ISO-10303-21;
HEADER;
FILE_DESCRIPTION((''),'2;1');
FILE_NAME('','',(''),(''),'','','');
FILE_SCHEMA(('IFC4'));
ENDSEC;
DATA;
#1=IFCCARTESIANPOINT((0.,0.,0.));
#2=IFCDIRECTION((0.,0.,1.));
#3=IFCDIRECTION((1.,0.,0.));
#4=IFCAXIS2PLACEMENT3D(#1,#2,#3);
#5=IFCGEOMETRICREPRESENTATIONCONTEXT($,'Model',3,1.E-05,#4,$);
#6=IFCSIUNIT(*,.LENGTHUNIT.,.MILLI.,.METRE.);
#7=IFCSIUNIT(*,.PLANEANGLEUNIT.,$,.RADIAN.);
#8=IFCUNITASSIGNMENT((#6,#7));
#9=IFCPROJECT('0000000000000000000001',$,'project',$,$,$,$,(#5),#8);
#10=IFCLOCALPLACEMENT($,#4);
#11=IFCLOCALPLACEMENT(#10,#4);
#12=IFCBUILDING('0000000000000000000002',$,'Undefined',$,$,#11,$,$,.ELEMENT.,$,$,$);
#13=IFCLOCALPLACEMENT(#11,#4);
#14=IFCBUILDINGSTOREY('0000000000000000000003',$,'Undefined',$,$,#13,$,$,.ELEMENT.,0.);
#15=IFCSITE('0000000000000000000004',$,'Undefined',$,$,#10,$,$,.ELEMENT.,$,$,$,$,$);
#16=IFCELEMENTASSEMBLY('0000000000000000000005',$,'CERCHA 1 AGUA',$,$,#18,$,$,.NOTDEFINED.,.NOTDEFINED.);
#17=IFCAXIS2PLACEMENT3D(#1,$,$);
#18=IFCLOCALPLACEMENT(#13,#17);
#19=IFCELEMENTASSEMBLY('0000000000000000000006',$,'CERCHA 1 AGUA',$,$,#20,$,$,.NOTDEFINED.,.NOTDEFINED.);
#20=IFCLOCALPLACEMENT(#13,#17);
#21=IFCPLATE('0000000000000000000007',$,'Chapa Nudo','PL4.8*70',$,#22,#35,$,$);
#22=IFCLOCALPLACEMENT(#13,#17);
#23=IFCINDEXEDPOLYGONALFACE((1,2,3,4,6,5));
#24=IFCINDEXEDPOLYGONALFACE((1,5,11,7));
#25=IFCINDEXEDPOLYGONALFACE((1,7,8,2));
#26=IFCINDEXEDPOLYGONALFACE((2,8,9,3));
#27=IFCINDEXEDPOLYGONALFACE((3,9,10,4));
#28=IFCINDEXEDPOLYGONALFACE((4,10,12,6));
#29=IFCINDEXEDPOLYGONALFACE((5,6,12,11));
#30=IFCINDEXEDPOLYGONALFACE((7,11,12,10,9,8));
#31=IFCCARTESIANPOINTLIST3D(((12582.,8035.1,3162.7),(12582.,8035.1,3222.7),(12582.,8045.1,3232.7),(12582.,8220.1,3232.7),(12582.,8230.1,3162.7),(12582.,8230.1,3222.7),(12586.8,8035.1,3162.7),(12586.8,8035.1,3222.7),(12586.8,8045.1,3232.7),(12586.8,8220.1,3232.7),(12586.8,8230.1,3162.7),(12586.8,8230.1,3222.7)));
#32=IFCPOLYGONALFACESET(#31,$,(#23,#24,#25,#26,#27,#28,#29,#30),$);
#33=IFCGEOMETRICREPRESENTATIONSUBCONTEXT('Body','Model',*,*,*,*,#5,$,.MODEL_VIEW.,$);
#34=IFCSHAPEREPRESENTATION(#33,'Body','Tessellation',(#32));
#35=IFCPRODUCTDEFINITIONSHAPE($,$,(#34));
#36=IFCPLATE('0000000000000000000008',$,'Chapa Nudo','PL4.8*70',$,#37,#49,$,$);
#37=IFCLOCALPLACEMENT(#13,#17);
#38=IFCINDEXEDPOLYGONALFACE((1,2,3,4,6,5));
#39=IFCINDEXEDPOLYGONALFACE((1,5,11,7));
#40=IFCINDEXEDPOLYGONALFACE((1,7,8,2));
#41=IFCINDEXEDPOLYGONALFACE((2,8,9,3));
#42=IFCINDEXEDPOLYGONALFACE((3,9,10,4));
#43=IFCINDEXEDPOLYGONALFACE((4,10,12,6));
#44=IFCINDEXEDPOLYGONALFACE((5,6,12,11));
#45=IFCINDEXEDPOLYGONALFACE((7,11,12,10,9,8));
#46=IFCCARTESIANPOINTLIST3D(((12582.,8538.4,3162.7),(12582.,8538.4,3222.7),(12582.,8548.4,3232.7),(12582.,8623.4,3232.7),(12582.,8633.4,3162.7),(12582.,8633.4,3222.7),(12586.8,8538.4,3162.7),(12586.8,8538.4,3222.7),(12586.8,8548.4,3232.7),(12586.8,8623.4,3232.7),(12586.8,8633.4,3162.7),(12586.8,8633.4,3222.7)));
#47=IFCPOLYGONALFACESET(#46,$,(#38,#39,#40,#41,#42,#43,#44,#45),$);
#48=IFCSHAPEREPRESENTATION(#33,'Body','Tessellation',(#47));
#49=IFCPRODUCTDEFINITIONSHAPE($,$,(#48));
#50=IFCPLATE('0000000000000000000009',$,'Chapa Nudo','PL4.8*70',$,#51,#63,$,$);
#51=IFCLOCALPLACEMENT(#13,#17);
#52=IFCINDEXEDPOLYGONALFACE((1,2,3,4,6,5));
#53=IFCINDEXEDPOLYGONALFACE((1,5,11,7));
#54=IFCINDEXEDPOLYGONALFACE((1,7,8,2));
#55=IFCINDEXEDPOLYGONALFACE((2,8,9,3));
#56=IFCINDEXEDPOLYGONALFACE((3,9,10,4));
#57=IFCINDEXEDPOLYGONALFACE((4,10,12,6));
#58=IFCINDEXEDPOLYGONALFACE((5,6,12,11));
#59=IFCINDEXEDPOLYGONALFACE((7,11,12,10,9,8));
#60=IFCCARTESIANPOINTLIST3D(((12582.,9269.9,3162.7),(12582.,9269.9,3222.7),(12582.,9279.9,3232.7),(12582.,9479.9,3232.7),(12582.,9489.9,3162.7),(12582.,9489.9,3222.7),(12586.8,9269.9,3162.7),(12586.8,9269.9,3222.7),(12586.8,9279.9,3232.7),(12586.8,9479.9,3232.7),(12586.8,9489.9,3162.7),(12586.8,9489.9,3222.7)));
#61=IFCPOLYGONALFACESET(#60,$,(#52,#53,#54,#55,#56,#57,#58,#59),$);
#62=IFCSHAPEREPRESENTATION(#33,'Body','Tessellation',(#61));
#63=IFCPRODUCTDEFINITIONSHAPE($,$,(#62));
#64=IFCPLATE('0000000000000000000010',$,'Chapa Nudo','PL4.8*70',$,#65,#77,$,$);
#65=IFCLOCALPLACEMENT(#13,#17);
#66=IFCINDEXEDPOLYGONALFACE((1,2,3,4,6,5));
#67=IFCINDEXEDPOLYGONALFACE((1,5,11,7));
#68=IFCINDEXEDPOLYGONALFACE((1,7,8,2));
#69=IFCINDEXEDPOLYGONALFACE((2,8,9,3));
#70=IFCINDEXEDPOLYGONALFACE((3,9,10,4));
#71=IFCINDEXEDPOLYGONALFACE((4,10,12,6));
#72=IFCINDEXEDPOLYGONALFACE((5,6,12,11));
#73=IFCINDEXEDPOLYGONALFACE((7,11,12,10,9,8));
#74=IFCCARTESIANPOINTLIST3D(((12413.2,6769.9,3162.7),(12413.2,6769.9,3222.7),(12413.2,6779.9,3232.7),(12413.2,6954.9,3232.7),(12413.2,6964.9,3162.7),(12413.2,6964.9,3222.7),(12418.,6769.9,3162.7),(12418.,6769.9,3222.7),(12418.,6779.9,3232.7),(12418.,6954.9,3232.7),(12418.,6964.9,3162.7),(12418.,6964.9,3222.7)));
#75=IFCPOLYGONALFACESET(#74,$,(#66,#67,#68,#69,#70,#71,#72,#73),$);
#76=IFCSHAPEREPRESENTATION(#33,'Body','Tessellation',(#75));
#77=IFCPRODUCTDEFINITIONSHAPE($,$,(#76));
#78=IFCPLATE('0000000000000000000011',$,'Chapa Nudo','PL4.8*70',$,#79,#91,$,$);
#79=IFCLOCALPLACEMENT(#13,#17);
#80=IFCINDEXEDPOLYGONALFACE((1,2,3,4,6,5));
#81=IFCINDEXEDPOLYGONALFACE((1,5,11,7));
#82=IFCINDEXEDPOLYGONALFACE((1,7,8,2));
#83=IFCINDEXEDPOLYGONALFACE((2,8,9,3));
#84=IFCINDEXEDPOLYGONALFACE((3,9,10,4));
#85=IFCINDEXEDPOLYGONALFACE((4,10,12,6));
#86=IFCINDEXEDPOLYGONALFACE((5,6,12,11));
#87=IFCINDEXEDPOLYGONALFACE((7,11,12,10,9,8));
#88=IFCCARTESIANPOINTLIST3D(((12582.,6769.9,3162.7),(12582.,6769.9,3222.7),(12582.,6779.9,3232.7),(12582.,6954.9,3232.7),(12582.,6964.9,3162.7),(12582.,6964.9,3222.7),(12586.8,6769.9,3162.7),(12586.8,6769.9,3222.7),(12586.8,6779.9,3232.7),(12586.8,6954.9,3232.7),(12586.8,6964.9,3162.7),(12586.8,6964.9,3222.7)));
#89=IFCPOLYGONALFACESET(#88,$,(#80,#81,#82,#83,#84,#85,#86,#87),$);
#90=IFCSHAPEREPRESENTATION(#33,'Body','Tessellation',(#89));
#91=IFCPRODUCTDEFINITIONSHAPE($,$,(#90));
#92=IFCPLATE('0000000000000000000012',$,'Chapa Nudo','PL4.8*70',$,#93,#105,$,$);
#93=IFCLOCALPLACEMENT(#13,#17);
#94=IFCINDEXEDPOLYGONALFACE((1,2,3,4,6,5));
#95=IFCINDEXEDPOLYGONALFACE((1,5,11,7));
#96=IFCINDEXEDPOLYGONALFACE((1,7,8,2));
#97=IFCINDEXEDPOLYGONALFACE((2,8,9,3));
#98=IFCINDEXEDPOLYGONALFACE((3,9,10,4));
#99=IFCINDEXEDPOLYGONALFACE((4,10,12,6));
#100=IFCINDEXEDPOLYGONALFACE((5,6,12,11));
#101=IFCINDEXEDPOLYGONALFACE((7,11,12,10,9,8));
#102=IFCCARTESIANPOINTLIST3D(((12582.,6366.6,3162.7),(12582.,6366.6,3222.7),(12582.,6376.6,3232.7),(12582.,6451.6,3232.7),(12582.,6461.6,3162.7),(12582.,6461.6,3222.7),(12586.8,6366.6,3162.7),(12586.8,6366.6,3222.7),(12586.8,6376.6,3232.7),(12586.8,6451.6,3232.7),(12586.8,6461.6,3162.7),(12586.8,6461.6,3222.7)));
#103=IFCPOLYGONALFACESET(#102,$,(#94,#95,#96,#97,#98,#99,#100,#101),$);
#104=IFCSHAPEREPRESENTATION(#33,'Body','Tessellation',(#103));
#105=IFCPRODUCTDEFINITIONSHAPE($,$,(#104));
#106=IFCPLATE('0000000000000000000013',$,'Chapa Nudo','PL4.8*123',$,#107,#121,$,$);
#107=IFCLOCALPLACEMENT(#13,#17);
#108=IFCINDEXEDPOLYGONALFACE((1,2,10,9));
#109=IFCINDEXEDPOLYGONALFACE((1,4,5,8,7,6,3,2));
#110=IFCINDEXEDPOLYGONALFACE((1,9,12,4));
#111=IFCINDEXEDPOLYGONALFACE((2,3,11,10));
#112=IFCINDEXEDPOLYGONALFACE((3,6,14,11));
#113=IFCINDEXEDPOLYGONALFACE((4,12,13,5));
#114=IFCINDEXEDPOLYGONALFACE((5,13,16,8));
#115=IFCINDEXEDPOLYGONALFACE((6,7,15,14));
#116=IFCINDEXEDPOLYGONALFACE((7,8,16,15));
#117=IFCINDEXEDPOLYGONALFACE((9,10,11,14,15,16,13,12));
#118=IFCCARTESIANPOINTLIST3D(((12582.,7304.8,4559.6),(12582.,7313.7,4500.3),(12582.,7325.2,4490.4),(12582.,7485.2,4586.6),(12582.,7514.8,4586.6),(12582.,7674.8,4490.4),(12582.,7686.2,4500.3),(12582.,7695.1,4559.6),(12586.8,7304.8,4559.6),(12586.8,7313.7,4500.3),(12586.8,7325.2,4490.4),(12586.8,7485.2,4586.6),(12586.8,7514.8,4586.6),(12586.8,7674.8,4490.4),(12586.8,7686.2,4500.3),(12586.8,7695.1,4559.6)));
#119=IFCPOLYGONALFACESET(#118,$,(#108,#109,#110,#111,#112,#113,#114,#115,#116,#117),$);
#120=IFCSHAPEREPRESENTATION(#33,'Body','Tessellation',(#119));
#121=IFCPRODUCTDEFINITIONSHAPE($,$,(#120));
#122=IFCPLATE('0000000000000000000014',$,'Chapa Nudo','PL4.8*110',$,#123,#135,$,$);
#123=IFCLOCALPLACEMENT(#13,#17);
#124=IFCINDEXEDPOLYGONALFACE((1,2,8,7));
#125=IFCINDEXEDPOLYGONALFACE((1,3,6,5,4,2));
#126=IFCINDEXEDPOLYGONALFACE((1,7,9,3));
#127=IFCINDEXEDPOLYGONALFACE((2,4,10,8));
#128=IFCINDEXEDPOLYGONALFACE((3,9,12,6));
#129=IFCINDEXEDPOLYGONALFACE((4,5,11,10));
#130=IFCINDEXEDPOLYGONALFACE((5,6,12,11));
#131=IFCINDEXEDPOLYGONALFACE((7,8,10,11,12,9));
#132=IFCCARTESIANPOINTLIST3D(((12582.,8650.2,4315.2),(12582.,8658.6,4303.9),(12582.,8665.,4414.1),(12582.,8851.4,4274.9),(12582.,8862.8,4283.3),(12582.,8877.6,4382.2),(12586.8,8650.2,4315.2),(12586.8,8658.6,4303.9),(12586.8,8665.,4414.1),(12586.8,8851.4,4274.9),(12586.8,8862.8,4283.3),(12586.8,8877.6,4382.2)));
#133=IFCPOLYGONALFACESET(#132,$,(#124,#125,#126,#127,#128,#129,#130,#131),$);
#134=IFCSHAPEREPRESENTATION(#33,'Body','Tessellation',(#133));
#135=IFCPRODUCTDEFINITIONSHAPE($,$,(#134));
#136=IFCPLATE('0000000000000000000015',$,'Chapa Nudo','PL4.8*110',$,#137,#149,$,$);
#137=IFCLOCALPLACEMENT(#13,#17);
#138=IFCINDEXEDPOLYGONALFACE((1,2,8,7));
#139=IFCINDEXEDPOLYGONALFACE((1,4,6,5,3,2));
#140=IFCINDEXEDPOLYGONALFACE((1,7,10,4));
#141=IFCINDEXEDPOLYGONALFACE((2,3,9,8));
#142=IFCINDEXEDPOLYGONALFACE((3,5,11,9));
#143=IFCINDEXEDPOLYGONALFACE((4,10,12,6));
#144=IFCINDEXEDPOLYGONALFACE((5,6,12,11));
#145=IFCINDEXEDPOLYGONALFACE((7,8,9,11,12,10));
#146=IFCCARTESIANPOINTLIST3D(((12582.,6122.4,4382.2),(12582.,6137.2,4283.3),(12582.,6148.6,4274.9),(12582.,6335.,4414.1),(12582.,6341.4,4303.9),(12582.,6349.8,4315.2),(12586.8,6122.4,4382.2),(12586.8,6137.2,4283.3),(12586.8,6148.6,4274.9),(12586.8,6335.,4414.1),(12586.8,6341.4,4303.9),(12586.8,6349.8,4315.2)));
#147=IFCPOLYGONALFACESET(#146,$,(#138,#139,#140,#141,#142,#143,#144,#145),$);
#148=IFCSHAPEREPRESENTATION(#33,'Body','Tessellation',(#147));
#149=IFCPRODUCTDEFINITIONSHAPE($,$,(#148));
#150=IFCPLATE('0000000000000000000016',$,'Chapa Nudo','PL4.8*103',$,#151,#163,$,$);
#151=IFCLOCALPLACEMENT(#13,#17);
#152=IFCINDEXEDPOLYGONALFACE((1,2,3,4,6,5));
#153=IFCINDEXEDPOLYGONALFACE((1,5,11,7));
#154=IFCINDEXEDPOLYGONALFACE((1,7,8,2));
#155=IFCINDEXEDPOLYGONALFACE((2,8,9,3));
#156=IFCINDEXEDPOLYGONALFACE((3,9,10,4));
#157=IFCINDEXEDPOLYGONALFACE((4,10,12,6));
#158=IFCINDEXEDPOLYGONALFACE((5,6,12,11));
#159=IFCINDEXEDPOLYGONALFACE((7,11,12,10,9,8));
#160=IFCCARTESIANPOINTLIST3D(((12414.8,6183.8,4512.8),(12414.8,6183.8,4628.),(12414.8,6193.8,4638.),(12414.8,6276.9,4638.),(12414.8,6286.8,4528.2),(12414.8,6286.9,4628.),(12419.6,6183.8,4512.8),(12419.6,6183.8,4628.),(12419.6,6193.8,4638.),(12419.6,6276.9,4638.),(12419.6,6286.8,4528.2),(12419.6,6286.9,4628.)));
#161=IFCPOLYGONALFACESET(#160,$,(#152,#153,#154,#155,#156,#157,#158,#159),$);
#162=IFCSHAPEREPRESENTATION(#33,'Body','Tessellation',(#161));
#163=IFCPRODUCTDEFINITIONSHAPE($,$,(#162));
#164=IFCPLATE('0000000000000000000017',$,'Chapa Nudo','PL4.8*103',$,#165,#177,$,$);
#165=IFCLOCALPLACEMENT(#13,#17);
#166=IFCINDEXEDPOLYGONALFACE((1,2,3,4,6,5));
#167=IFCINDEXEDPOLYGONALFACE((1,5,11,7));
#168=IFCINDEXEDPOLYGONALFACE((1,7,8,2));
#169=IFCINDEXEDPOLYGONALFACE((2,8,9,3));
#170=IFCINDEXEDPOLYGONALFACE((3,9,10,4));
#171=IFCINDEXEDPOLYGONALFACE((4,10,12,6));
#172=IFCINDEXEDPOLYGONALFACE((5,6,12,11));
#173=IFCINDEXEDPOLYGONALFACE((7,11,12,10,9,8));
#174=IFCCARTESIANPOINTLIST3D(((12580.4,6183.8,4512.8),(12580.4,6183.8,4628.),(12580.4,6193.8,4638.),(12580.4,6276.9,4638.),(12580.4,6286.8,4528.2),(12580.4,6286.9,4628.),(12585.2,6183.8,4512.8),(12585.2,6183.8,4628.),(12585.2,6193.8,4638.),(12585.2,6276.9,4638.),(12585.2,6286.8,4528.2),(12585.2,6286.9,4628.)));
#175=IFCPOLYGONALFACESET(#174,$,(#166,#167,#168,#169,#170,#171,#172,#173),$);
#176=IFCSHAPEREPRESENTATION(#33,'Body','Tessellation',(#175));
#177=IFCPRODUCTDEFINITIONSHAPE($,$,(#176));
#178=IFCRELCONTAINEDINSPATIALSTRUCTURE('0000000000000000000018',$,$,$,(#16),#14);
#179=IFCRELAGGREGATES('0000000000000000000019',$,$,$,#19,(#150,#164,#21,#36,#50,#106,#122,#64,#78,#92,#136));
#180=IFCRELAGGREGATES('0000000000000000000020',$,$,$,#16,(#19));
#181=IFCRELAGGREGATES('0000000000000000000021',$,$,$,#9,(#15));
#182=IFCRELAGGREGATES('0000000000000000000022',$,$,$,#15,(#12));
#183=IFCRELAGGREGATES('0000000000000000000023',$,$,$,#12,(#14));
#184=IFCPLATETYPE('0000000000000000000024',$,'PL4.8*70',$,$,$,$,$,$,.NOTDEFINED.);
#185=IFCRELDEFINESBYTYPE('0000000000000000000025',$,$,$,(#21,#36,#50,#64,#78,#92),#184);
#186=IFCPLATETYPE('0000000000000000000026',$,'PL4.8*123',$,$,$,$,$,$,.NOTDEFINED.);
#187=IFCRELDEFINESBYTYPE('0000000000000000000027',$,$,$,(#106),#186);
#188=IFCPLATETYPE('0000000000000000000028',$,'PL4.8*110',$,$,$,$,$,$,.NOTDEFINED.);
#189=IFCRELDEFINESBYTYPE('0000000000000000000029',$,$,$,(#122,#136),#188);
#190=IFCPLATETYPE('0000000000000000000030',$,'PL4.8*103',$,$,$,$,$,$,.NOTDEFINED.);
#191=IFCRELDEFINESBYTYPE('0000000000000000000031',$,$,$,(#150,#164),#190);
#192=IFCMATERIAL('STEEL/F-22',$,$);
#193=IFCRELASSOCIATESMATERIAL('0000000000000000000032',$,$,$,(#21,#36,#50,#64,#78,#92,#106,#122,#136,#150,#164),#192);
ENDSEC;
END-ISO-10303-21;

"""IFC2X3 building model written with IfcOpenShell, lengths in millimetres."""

from ifc_helpers import new_model, si_unit, frame, origin_with_axes, place, context, subcontext, project, spatial, polyline, outline, extrude, material, type_object, element, aggregate, save


model = new_model("IFC2X3")

# Units and contexts
model_context = context("Model", 3, precision=1e-05, world=origin_with_axes())
body_context = subcontext(model_context, "Body", "Model", "MODEL_VIEW")
ifc_project = project(units=[si_unit("LENGTHUNIT", "METRE", prefix="MILLI"), si_unit("PLANEANGLEUNIT", "RADIAN")], contexts=[model_context])

# Site, building, storey
site_placement = place(None, origin_with_axes())
site = spatial("IfcSite", under=ifc_project, at=site_placement, Name="Undefined", CompositionType="ELEMENT")
building_placement = place(site_placement, origin_with_axes())
building = spatial("IfcBuilding", under=site, at=building_placement, Name="Undefined", CompositionType="ELEMENT")
storey_placement = place(building_placement, origin_with_axes())
storey = spatial("IfcBuildingStorey", under=building, at=storey_placement, Name="Undefined", CompositionType="ELEMENT", Elevation=0.0)

# Element assemblies, plates
assembly_1_placement = place(storey_placement, origin_with_axes())
assembly_1 = element("IfcElementAssembly", 1, at=assembly_1_placement, inside=storey, Name="CERCHA 1 AGUA", AssemblyPlace="NOTDEFINED", PredefinedType="NOTDEFINED")
assembly_2_placement = place(assembly_1_placement, origin_with_axes())
assembly_2 = element("IfcElementAssembly", 2, at=assembly_2_placement, Name="CERCHA 1 AGUA", AssemblyPlace="NOTDEFINED", PredefinedType="NOTDEFINED")
ifc_material_1 = material(Name="STEEL/F-22")
plate_type_1 = type_object("IfcPlateType", Name="PL4.8*70", PredefinedType="NOTDEFINED")
plate_1_placement = place(assembly_2_placement, frame((12584.4, 8230.1, 3232.7), z_axis=(-1.0, 0.0, 0.0), x_axis=(0.0, 0.0, -1.0)))
plate_1 = element("IfcPlate", 3, at=plate_1_placement, type_object=plate_type_1, material=ifc_material_1, Name="Chapa Nudo", Description="PL4.8*70", context=body_context, shape_type="SweptSolid", body=[
    extrude(outline(polyline([(0.0, 10.0), (10.0, 0.0), (70.0, 0.0), (70.0, 195.0), (10.0, 195.0), (0.0, 185.0), (0.0, 10.0)])), frame((0.0, 0.0, -2.4), z_axis=(0.0, 0.0, 1.0), x_axis=(1.0, 0.0, 0.0)), (0.0, 0.0, 1.0), 4.8),
])
plate_2_placement = place(assembly_2_placement, frame((12584.4, 8633.4, 3232.7), z_axis=(-1.0, 0.0, 0.0), x_axis=(0.0, 0.0, -1.0)))
plate_2 = element("IfcPlate", 4, at=plate_2_placement, type_object=plate_type_1, material=ifc_material_1, Name="Chapa Nudo", Description="PL4.8*70", context=body_context, shape_type="SweptSolid", body=[
    extrude(outline(polyline([(0.0, 10.0), (10.0, 0.0), (70.0, 0.0), (70.0, 95.0), (10.0, 95.0), (0.0, 85.0), (0.0, 10.0)])), frame((0.0, 0.0, -2.4), z_axis=(0.0, 0.0, 1.0), x_axis=(1.0, 0.0, 0.0)), (0.0, 0.0, 1.0), 4.8),
])
plate_3_placement = place(assembly_2_placement, frame((12584.4, 9489.9, 3232.7), z_axis=(-1.0, 0.0, 0.0), x_axis=(0.0, 0.0, -1.0)))
plate_3 = element("IfcPlate", 5, at=plate_3_placement, type_object=plate_type_1, material=ifc_material_1, Name="Chapa Nudo", Description="PL4.8*70", context=body_context, shape_type="SweptSolid", body=[
    extrude(outline(polyline([(0.0, 10.0), (10.0, 0.0), (70.0, 0.0), (70.0, 220.0), (10.0, 220.0), (0.0, 210.0), (0.0, 10.0)])), frame((0.0, 0.0, -2.4), z_axis=(0.0, 0.0, 1.0), x_axis=(1.0, 0.0, 0.0)), (0.0, 0.0, 1.0), 4.8),
])
plate_4_placement = place(assembly_2_placement, frame((12415.6, 6769.9, 3232.7), z_axis=(1.0, 0.0, 0.0), x_axis=(0.0, 0.0, -1.0)))
plate_4 = element("IfcPlate", 6, at=plate_4_placement, type_object=plate_type_1, material=ifc_material_1, Name="Chapa Nudo", Description="PL4.8*70", context=body_context, shape_type="SweptSolid", body=[
    extrude(outline(polyline([(0.0, 10.0), (10.0, 0.0), (70.0, 0.0), (70.0, 195.0), (10.0, 195.0), (0.0, 185.0), (0.0, 10.0)])), frame((0.0, 0.0, -2.4), z_axis=(0.0, 0.0, 1.0), x_axis=(1.0, 0.0, 0.0)), (0.0, 0.0, 1.0), 4.8),
])
plate_5_placement = place(assembly_2_placement, frame((12584.4, 6769.9, 3232.7), z_axis=(1.0, 0.0, 0.0), x_axis=(0.0, 0.0, -1.0)))
plate_5 = element("IfcPlate", 7, at=plate_5_placement, type_object=plate_type_1, material=ifc_material_1, Name="Chapa Nudo", Description="PL4.8*70", context=body_context, shape_type="SweptSolid", body=[
    extrude(outline(polyline([(0.0, 10.0), (10.0, 0.0), (70.0, 0.0), (70.0, 195.0), (10.0, 195.0), (0.0, 185.0), (0.0, 10.0)])), frame((0.0, 0.0, -2.4), z_axis=(0.0, 0.0, 1.0), x_axis=(1.0, 0.0, 0.0)), (0.0, 0.0, 1.0), 4.8),
])
plate_6_placement = place(assembly_2_placement, frame((12584.4, 6366.6, 3232.7), z_axis=(1.0, 0.0, 0.0), x_axis=(0.0, 0.0, -1.0)))
plate_6 = element("IfcPlate", 8, at=plate_6_placement, type_object=plate_type_1, material=ifc_material_1, Name="Chapa Nudo", Description="PL4.8*70", context=body_context, shape_type="SweptSolid", body=[
    extrude(outline(polyline([(0.0, 10.0), (10.0, 0.0), (70.0, 0.0), (70.0, 95.0), (10.0, 95.0), (0.0, 85.0), (0.0, 10.0)])), frame((0.0, 0.0, -2.4), z_axis=(0.0, 0.0, 1.0), x_axis=(1.0, 0.0, 0.0)), (0.0, 0.0, 1.0), 4.8),
])
plate_type_2 = type_object("IfcPlateType", Name="PL4.8*123", PredefinedType="NOTDEFINED")
plate_7_placement = place(assembly_2_placement, frame((12584.4, 7695.1, 4559.6), z_axis=(-1.0, 0.0, 0.0), x_axis=(0.0, -0.148335, -0.988937)))
plate_7 = element("IfcPlate", 9, at=plate_7_placement, type_object=plate_type_2, material=ifc_material_1, Name="Chapa Nudo", Description="PL4.8*123", context=body_context, shape_type="SweptSolid", body=[
    extrude(outline(polyline([(0.0, 0.0), (60.0, 0.0), (71.5, 9.9), (123.3, 355.6), (115.3, 368.4), (57.9, 386.0), (4.4, 211.7), (0.0, 182.3), (0.0, 0.0)])), frame((0.0, 0.0, -2.4), z_axis=(0.0, 0.0, 1.0), x_axis=(1.0, 0.0, 0.0)), (0.0, 0.0, 1.0), 4.8),
])
plate_type_3 = type_object("IfcPlateType", Name="PL4.8*110", PredefinedType="NOTDEFINED")
plate_8_placement = place(assembly_2_placement, frame((12584.4, 8877.6, 4382.2), z_axis=(-1.0, 0.0, 0.0), x_axis=(0.0, -0.148335, -0.988937)))
plate_8 = element("IfcPlate", 10, at=plate_8_placement, type_object=plate_type_3, material=ifc_material_1, Name="Chapa Nudo", Description="PL4.8*110", context=body_context, shape_type="SweptSolid", body=[
    extrude(outline(polyline([(0.0, 0.0), (100.0, 0.0), (110.0, 10.0), (110.0, 205.0), (100.0, 215.0), (0.0, 215.0), (0.0, 0.0)])), frame((0.0, 0.0, -2.4), z_axis=(0.0, 0.0, 1.0), x_axis=(1.0, 0.0, 0.0)), (0.0, 0.0, 1.0), 4.8),
])
plate_9_placement = place(assembly_2_placement, frame((12584.4, 6122.4, 4382.2), z_axis=(1.0, 0.0, 0.0), x_axis=(0.0, 0.148335, -0.988937)))
plate_9 = element("IfcPlate", 11, at=plate_9_placement, type_object=plate_type_3, material=ifc_material_1, Name="Chapa Nudo", Description="PL4.8*110", context=body_context, shape_type="SweptSolid", body=[
    extrude(outline(polyline([(0.0, 0.0), (100.0, 0.0), (110.0, 10.0), (110.0, 205.0), (100.0, 215.0), (0.0, 215.0), (0.0, 0.0)])), frame((0.0, 0.0, -2.4), z_axis=(0.0, 0.0, 1.0), x_axis=(1.0, 0.0, 0.0)), (0.0, 0.0, 1.0), 4.8),
])
plate_type_4 = type_object("IfcPlateType", Name="PL4.8*103", PredefinedType="NOTDEFINED")
plate_10_placement = place(assembly_2_placement, frame((12417.2, 6183.8, 4638.0), z_axis=(1.0, 0.0, 0.0), x_axis=(0.0, 0.000133, -1.0)))
plate_10 = element("IfcPlate", 12, at=plate_10_placement, type_object=plate_type_4, material=ifc_material_1, Name="Chapa Nudo", Description="PL4.8*103", context=body_context, shape_type="SweptSolid", body=[
    extrude(outline(polyline([(0.0, 10.0), (10.0, 0.0), (125.2, 0.0), (109.7, 103.0), (10.0, 103.0), (0.0, 93.0), (0.0, 10.0)])), frame((0.0, 0.0, -2.4), z_axis=(0.0, 0.0, 1.0), x_axis=(1.0, 0.0, 0.0)), (0.0, 0.0, 1.0), 4.8),
])
plate_11_placement = place(assembly_2_placement, frame((12582.8, 6183.8, 4638.0), z_axis=(1.0, 0.0, 0.0), x_axis=(0.0, 0.000133, -1.0)))
plate_11 = element("IfcPlate", 13, at=plate_11_placement, type_object=plate_type_4, material=ifc_material_1, Name="Chapa Nudo", Description="PL4.8*103", context=body_context, shape_type="SweptSolid", body=[
    extrude(outline(polyline([(0.0, 10.0), (10.0, 0.0), (125.2, 0.0), (109.7, 103.0), (10.0, 103.0), (0.0, 93.0), (0.0, 10.0)])), frame((0.0, 0.0, -2.4), z_axis=(0.0, 0.0, 1.0), x_axis=(1.0, 0.0, 0.0)), (0.0, 0.0, 1.0), 4.8),
])

aggregate(assembly_2, [plate_10, plate_11, plate_1, plate_2, plate_3, plate_7, plate_8, plate_4, plate_5, plate_6, plate_9])
aggregate(assembly_1, [assembly_2])

save(model, "model.ifc")
